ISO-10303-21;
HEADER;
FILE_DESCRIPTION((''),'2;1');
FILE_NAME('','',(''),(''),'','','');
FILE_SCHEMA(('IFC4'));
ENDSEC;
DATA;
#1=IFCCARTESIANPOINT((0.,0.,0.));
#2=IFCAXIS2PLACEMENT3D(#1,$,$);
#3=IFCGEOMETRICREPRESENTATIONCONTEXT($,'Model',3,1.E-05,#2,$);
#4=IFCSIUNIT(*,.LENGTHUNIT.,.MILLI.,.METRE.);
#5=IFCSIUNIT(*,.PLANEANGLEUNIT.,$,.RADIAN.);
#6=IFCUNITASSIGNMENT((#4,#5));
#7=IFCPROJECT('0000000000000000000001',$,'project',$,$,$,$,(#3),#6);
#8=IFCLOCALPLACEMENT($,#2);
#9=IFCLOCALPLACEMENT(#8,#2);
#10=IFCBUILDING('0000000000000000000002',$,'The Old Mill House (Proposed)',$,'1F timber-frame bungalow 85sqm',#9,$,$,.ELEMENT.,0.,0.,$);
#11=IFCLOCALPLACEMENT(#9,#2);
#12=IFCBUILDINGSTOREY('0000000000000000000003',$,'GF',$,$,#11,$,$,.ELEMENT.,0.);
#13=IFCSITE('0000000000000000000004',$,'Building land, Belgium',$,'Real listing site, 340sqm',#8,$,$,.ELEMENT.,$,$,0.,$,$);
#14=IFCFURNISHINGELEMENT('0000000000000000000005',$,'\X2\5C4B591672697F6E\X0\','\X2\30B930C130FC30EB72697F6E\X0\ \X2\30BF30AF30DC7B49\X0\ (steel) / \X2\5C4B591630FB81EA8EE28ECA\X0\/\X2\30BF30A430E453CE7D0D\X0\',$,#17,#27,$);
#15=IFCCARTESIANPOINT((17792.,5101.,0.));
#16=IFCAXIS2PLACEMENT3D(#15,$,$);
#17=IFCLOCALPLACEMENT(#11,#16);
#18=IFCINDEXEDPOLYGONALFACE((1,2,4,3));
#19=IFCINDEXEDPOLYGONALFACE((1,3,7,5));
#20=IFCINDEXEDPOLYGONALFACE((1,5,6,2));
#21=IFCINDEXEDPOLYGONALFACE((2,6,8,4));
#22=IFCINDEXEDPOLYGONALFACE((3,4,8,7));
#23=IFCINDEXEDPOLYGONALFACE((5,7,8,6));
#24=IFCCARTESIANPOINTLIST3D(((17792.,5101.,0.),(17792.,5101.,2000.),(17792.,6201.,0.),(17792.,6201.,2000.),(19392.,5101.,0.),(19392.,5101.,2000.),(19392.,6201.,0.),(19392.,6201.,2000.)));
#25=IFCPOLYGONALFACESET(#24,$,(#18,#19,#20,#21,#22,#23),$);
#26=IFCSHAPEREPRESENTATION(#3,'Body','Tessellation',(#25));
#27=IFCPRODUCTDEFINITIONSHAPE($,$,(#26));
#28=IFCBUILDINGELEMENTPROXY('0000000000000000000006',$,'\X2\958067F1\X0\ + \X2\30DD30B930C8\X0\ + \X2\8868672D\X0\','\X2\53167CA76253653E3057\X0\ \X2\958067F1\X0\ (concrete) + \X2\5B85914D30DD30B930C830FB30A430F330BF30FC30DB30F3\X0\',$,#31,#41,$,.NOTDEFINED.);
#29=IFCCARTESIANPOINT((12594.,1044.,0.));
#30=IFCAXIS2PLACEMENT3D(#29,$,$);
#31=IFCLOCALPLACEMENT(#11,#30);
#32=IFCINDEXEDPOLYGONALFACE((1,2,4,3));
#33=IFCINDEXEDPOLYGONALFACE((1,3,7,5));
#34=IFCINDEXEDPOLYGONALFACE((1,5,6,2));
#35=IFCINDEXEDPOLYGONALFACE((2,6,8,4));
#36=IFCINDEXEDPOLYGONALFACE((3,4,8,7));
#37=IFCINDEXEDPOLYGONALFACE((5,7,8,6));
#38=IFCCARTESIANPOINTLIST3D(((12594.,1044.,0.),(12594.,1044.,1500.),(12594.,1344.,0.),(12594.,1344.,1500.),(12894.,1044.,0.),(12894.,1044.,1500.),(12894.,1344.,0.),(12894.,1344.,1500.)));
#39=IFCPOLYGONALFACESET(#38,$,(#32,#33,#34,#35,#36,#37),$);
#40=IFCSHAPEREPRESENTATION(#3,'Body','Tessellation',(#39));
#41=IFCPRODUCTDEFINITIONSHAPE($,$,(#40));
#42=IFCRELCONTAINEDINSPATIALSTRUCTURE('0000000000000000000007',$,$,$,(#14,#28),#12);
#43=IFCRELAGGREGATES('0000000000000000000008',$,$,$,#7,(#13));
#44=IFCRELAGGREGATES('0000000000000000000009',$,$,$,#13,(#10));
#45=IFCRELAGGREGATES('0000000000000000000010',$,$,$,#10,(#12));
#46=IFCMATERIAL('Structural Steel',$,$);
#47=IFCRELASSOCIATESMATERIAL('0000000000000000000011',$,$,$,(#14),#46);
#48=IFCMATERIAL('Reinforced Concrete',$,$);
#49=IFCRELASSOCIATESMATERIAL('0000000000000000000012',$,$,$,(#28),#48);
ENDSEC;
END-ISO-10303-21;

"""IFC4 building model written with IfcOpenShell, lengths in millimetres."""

from ifc_helpers import new_model, si_unit, frame, frame_2d, origin, place, context, project, spatial, rectangle, extrude, material, element, save


model = new_model("IFC4")

# Units and contexts
model_context = context("Model", 3, precision=1e-05, world=origin())
ifc_project = project(units=[si_unit("LENGTHUNIT", "METRE", prefix="MILLI"), si_unit("PLANEANGLEUNIT", "RADIAN")], contexts=[model_context])

# Site, building, storey
site_placement = place(None, origin())
site = spatial("IfcSite", under=ifc_project, at=site_placement, Name="Building land, Belgium", ObjectType="Real listing site, 340sqm", CompositionType="ELEMENT", RefElevation=0.0)
building_placement = place(site_placement, origin())
building = spatial("IfcBuilding", under=site, at=building_placement, Name="The Old Mill House (Proposed)", ObjectType="1F timber-frame bungalow 85sqm", CompositionType="ELEMENT", ElevationOfRefHeight=0.0, ElevationOfTerrain=0.0)
storey_placement = place(building_placement, origin())
storey = spatial("IfcBuildingStorey", under=building, at=storey_placement, Name="GF", CompositionType="ELEMENT", Elevation=0.0)

# Shared definitions
ifc_material_1 = material(Name="Reinforced Concrete")

# Shared definitions
ifc_material_2 = material(Name="Structural Steel")

# Furnishing element
furnishing_1_placement = place(storey_placement, frame((17792.0, 5101.0, 0.0)))
element("IfcFurnishingElement", 1, at=furnishing_1_placement, inside=storey, material=ifc_material_2, Name="屋外物置", Description="スチール物置 タクボ等 (steel) / 屋外・自転車/タイヤ収納", context=model_context, shape_type="SweptSolid", body=[
    extrude(rectangle(XDim=1600.0, YDim=1100.0, at=frame_2d((800.0, 550.0))), frame((17792.0, 5101.0, 0.0)), (0.0, 0.0, 1.0), 2000.0),
])

# Building element proxy
proxy_placement = place(storey_placement, frame((12594.0, 1044.0, 0.0)))
element("IfcBuildingElementProxy", 2, at=proxy_placement, inside=storey, material=ifc_material_1, Name="門柱 + ポスト + 表札", Description="化粧打放し 門柱 (concrete) + 宅配ポスト・インターホン", PredefinedType="NOTDEFINED", context=model_context, shape_type="SweptSolid", body=[
    extrude(rectangle(XDim=300.0, YDim=300.0, at=frame_2d((150.0, 150.0))), frame((12594.0, 1044.0, 0.0)), (0.0, 0.0, 1.0), 1500.0),
])

save(model, "model.ifc")
